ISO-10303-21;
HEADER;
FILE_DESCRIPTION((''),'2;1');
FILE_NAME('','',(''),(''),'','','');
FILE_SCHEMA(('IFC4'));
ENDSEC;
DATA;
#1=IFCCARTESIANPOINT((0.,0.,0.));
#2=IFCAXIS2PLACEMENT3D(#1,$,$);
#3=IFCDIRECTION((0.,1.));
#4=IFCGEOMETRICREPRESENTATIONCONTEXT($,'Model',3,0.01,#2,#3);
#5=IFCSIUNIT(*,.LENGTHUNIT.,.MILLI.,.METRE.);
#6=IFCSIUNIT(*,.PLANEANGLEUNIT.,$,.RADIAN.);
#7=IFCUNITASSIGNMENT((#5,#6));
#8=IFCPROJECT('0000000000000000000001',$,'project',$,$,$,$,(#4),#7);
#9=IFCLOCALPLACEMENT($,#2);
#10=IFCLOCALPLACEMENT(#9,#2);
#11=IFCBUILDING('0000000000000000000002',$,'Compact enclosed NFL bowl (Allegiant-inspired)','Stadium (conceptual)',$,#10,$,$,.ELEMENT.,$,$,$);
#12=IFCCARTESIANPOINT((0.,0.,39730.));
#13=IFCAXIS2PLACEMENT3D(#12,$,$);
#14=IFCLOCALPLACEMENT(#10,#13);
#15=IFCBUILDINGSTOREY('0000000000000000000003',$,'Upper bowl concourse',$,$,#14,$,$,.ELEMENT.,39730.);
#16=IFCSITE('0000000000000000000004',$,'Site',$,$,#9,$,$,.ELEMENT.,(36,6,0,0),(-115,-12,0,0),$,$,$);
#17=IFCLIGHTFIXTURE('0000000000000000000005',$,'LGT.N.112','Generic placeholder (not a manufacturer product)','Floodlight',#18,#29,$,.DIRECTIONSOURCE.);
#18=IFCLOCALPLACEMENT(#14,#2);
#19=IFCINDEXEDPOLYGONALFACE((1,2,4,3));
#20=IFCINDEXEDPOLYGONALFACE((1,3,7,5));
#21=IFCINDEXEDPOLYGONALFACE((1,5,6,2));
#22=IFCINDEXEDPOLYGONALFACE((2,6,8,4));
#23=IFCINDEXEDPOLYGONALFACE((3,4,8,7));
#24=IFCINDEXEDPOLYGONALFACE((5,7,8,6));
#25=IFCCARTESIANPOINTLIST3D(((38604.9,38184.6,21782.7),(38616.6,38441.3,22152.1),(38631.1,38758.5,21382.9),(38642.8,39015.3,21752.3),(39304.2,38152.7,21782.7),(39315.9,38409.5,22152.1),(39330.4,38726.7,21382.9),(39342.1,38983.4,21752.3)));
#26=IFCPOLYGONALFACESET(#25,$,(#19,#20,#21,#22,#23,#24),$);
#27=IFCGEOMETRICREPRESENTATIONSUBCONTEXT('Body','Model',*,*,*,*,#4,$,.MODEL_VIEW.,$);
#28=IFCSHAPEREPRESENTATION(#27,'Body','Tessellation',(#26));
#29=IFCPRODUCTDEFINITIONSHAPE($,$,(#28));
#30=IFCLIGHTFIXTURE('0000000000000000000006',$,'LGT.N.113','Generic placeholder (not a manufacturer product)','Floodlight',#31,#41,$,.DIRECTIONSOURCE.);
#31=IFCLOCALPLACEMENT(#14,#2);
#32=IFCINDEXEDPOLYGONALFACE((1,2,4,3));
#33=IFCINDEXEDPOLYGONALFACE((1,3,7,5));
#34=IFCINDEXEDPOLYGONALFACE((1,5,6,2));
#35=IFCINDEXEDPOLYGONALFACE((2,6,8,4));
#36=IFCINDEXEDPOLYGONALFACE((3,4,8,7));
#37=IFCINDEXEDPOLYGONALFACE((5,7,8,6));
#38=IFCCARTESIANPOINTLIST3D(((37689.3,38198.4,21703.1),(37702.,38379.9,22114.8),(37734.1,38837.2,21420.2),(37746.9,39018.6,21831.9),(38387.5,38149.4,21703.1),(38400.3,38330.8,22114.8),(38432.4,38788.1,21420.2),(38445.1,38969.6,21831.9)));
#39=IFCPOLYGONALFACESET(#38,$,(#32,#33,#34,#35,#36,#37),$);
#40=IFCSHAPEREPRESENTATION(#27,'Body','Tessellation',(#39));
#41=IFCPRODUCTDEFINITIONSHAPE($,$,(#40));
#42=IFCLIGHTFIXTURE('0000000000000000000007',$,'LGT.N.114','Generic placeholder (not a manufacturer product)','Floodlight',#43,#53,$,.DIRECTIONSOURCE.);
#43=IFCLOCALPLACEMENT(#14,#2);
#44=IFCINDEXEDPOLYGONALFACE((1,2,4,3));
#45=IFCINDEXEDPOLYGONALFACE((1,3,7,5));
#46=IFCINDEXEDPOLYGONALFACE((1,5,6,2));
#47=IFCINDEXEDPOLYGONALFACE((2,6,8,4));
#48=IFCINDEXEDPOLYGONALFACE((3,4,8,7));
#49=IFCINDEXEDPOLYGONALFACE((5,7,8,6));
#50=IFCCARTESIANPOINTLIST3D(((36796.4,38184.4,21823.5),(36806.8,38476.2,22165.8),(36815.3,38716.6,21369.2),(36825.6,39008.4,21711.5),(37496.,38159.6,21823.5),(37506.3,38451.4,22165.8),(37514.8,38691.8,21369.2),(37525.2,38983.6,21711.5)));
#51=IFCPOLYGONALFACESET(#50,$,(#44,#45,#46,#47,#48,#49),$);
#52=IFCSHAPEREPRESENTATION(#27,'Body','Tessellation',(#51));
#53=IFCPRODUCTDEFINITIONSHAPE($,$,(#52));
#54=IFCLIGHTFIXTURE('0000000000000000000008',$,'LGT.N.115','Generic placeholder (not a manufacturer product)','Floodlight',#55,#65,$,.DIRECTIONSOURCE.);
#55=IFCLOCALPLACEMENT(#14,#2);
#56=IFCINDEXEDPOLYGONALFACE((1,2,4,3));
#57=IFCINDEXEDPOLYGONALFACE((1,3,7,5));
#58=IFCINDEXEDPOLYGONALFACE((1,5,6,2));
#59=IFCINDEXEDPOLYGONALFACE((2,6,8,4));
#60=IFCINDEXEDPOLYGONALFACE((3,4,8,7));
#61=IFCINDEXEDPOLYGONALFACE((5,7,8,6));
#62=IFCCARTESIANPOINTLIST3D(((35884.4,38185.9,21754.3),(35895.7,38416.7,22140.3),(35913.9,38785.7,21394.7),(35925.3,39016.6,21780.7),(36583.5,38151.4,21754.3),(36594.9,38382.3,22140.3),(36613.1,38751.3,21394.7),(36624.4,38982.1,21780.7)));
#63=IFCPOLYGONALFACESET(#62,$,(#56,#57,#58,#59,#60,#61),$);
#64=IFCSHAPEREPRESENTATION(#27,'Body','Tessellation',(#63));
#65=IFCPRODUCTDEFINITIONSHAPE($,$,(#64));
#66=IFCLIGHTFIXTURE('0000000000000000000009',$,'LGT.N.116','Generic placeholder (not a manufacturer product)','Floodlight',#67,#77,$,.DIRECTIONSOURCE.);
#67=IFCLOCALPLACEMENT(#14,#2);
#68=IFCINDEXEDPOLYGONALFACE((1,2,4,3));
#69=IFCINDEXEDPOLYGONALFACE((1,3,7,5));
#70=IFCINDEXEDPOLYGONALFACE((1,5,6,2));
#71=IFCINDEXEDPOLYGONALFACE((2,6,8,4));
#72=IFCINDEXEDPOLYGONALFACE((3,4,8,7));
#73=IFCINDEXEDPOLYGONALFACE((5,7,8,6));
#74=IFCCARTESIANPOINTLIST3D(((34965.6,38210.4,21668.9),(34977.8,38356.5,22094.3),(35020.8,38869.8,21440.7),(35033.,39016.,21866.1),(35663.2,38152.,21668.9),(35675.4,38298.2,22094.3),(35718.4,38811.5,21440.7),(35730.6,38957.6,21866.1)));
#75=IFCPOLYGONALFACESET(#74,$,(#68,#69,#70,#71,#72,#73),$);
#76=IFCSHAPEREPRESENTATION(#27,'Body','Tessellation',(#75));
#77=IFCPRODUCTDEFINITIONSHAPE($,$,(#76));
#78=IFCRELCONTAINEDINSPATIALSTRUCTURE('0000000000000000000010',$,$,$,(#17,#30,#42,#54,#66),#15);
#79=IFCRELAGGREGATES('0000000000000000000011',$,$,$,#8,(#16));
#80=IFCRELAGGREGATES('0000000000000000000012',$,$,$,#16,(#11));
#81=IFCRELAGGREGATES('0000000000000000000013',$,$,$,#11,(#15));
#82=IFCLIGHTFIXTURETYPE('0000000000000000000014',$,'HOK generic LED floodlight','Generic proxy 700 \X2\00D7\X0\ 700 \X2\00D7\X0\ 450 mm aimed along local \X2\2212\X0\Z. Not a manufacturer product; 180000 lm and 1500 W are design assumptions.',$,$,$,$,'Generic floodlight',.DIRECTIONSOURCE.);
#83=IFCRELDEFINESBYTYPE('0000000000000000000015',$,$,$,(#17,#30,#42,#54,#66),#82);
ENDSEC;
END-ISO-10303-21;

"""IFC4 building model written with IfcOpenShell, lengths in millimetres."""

from ifc_helpers import new_model, si_unit, direction, frame, origin, place, context, subcontext, project, spatial, rectangle, extrude, source, transform, mapped, type_object, type_shapes, element, save


model = new_model("IFC4")

# Units and contexts
model_context = context("Model", 3, precision=0.01, world=origin(), true_north=direction((0.0, 1.0)))
body_context = subcontext(model_context, "Body", "Model", "MODEL_VIEW")
ifc_project = project(units=[si_unit("LENGTHUNIT", "METRE", prefix="MILLI"), si_unit("PLANEANGLEUNIT", "RADIAN")], contexts=[model_context])

# Site, building, storey
site_placement = place(None, origin())
site = spatial("IfcSite", under=ifc_project, at=site_placement, Name="Site", CompositionType="ELEMENT", RefLatitude=(36, 6, 0, 0), RefLongitude=(-115, -12, 0, 0))
building_placement = place(site_placement, origin())
building = spatial("IfcBuilding", under=site, at=building_placement, Name="Compact enclosed NFL bowl (Allegiant-inspired)", Description="Stadium (conceptual)", CompositionType="ELEMENT")
storey_placement = place(building_placement, frame((0.0, 0.0, 39730.0)))
storey = spatial("IfcBuildingStorey", under=building, at=storey_placement, Name="Upper bowl concourse", CompositionType="ELEMENT", Elevation=39730.0)

# Light fixtures
light_fixture_type = type_object("IfcLightFixtureType", Name="HOK generic LED floodlight", Description="Generic proxy 700 × 700 × 450 mm aimed along local −Z. Not a manufacturer product; 180000 lm and 1500 W are design assumptions.", ElementType="Generic floodlight", PredefinedType="DIRECTIONSOURCE")
shared_shape = source(origin(), body_context, "Body", "SweptSolid", [
    extrude(rectangle(XDim=700.0, YDim=700.0), frame((0.0, 0.0, -225.0)), (0.0, 0.0, 1.0), 450.0),
])
type_shapes(light_fixture_type, [shared_shape])
for number, where, z_axis, x_axis, name in (
    (1, (38973.5, 38584.0, 21767.5), (0.026009, 0.570622, 0.820801), (-0.998963, 0.045532, 0.0), "LGT.N.112"),
    (2, (38067.2, 38584.0, 21767.5), (0.02831, 0.403162, 0.914691), (-0.997544, 0.070047, 0.0), "LGT.N.113"),
    (3, (37160.8, 38584.0, 21767.5), (0.022987, 0.64856, 0.760816), (-0.999372, 0.035421, 0.0), "LGT.N.114"),
    (4, (36254.4, 38584.0, 21767.5), (0.02529, 0.513078, 0.857969), (-0.998787, 0.049231, 0.0), "LGT.N.115"),
    (5, (35348.1, 38584.0, 21767.5), (0.02717, 0.324813, 0.945388), (-0.99652, 0.083357, 0.0), "LGT.N.116"),
):
    element("IfcLightFixture", number, at=place(storey_placement, frame(where, z_axis=z_axis, x_axis=x_axis)), inside=storey, type_object=light_fixture_type, Name=name, Description="Generic placeholder (not a manufacturer product)", ObjectType="Floodlight", PredefinedType="DIRECTIONSOURCE", context=body_context, shape_type="MappedRepresentation", body=[
        mapped(shared_shape, transform((0.0, 0.0, 0.0))),
    ])

save(model, "model.ifc")
